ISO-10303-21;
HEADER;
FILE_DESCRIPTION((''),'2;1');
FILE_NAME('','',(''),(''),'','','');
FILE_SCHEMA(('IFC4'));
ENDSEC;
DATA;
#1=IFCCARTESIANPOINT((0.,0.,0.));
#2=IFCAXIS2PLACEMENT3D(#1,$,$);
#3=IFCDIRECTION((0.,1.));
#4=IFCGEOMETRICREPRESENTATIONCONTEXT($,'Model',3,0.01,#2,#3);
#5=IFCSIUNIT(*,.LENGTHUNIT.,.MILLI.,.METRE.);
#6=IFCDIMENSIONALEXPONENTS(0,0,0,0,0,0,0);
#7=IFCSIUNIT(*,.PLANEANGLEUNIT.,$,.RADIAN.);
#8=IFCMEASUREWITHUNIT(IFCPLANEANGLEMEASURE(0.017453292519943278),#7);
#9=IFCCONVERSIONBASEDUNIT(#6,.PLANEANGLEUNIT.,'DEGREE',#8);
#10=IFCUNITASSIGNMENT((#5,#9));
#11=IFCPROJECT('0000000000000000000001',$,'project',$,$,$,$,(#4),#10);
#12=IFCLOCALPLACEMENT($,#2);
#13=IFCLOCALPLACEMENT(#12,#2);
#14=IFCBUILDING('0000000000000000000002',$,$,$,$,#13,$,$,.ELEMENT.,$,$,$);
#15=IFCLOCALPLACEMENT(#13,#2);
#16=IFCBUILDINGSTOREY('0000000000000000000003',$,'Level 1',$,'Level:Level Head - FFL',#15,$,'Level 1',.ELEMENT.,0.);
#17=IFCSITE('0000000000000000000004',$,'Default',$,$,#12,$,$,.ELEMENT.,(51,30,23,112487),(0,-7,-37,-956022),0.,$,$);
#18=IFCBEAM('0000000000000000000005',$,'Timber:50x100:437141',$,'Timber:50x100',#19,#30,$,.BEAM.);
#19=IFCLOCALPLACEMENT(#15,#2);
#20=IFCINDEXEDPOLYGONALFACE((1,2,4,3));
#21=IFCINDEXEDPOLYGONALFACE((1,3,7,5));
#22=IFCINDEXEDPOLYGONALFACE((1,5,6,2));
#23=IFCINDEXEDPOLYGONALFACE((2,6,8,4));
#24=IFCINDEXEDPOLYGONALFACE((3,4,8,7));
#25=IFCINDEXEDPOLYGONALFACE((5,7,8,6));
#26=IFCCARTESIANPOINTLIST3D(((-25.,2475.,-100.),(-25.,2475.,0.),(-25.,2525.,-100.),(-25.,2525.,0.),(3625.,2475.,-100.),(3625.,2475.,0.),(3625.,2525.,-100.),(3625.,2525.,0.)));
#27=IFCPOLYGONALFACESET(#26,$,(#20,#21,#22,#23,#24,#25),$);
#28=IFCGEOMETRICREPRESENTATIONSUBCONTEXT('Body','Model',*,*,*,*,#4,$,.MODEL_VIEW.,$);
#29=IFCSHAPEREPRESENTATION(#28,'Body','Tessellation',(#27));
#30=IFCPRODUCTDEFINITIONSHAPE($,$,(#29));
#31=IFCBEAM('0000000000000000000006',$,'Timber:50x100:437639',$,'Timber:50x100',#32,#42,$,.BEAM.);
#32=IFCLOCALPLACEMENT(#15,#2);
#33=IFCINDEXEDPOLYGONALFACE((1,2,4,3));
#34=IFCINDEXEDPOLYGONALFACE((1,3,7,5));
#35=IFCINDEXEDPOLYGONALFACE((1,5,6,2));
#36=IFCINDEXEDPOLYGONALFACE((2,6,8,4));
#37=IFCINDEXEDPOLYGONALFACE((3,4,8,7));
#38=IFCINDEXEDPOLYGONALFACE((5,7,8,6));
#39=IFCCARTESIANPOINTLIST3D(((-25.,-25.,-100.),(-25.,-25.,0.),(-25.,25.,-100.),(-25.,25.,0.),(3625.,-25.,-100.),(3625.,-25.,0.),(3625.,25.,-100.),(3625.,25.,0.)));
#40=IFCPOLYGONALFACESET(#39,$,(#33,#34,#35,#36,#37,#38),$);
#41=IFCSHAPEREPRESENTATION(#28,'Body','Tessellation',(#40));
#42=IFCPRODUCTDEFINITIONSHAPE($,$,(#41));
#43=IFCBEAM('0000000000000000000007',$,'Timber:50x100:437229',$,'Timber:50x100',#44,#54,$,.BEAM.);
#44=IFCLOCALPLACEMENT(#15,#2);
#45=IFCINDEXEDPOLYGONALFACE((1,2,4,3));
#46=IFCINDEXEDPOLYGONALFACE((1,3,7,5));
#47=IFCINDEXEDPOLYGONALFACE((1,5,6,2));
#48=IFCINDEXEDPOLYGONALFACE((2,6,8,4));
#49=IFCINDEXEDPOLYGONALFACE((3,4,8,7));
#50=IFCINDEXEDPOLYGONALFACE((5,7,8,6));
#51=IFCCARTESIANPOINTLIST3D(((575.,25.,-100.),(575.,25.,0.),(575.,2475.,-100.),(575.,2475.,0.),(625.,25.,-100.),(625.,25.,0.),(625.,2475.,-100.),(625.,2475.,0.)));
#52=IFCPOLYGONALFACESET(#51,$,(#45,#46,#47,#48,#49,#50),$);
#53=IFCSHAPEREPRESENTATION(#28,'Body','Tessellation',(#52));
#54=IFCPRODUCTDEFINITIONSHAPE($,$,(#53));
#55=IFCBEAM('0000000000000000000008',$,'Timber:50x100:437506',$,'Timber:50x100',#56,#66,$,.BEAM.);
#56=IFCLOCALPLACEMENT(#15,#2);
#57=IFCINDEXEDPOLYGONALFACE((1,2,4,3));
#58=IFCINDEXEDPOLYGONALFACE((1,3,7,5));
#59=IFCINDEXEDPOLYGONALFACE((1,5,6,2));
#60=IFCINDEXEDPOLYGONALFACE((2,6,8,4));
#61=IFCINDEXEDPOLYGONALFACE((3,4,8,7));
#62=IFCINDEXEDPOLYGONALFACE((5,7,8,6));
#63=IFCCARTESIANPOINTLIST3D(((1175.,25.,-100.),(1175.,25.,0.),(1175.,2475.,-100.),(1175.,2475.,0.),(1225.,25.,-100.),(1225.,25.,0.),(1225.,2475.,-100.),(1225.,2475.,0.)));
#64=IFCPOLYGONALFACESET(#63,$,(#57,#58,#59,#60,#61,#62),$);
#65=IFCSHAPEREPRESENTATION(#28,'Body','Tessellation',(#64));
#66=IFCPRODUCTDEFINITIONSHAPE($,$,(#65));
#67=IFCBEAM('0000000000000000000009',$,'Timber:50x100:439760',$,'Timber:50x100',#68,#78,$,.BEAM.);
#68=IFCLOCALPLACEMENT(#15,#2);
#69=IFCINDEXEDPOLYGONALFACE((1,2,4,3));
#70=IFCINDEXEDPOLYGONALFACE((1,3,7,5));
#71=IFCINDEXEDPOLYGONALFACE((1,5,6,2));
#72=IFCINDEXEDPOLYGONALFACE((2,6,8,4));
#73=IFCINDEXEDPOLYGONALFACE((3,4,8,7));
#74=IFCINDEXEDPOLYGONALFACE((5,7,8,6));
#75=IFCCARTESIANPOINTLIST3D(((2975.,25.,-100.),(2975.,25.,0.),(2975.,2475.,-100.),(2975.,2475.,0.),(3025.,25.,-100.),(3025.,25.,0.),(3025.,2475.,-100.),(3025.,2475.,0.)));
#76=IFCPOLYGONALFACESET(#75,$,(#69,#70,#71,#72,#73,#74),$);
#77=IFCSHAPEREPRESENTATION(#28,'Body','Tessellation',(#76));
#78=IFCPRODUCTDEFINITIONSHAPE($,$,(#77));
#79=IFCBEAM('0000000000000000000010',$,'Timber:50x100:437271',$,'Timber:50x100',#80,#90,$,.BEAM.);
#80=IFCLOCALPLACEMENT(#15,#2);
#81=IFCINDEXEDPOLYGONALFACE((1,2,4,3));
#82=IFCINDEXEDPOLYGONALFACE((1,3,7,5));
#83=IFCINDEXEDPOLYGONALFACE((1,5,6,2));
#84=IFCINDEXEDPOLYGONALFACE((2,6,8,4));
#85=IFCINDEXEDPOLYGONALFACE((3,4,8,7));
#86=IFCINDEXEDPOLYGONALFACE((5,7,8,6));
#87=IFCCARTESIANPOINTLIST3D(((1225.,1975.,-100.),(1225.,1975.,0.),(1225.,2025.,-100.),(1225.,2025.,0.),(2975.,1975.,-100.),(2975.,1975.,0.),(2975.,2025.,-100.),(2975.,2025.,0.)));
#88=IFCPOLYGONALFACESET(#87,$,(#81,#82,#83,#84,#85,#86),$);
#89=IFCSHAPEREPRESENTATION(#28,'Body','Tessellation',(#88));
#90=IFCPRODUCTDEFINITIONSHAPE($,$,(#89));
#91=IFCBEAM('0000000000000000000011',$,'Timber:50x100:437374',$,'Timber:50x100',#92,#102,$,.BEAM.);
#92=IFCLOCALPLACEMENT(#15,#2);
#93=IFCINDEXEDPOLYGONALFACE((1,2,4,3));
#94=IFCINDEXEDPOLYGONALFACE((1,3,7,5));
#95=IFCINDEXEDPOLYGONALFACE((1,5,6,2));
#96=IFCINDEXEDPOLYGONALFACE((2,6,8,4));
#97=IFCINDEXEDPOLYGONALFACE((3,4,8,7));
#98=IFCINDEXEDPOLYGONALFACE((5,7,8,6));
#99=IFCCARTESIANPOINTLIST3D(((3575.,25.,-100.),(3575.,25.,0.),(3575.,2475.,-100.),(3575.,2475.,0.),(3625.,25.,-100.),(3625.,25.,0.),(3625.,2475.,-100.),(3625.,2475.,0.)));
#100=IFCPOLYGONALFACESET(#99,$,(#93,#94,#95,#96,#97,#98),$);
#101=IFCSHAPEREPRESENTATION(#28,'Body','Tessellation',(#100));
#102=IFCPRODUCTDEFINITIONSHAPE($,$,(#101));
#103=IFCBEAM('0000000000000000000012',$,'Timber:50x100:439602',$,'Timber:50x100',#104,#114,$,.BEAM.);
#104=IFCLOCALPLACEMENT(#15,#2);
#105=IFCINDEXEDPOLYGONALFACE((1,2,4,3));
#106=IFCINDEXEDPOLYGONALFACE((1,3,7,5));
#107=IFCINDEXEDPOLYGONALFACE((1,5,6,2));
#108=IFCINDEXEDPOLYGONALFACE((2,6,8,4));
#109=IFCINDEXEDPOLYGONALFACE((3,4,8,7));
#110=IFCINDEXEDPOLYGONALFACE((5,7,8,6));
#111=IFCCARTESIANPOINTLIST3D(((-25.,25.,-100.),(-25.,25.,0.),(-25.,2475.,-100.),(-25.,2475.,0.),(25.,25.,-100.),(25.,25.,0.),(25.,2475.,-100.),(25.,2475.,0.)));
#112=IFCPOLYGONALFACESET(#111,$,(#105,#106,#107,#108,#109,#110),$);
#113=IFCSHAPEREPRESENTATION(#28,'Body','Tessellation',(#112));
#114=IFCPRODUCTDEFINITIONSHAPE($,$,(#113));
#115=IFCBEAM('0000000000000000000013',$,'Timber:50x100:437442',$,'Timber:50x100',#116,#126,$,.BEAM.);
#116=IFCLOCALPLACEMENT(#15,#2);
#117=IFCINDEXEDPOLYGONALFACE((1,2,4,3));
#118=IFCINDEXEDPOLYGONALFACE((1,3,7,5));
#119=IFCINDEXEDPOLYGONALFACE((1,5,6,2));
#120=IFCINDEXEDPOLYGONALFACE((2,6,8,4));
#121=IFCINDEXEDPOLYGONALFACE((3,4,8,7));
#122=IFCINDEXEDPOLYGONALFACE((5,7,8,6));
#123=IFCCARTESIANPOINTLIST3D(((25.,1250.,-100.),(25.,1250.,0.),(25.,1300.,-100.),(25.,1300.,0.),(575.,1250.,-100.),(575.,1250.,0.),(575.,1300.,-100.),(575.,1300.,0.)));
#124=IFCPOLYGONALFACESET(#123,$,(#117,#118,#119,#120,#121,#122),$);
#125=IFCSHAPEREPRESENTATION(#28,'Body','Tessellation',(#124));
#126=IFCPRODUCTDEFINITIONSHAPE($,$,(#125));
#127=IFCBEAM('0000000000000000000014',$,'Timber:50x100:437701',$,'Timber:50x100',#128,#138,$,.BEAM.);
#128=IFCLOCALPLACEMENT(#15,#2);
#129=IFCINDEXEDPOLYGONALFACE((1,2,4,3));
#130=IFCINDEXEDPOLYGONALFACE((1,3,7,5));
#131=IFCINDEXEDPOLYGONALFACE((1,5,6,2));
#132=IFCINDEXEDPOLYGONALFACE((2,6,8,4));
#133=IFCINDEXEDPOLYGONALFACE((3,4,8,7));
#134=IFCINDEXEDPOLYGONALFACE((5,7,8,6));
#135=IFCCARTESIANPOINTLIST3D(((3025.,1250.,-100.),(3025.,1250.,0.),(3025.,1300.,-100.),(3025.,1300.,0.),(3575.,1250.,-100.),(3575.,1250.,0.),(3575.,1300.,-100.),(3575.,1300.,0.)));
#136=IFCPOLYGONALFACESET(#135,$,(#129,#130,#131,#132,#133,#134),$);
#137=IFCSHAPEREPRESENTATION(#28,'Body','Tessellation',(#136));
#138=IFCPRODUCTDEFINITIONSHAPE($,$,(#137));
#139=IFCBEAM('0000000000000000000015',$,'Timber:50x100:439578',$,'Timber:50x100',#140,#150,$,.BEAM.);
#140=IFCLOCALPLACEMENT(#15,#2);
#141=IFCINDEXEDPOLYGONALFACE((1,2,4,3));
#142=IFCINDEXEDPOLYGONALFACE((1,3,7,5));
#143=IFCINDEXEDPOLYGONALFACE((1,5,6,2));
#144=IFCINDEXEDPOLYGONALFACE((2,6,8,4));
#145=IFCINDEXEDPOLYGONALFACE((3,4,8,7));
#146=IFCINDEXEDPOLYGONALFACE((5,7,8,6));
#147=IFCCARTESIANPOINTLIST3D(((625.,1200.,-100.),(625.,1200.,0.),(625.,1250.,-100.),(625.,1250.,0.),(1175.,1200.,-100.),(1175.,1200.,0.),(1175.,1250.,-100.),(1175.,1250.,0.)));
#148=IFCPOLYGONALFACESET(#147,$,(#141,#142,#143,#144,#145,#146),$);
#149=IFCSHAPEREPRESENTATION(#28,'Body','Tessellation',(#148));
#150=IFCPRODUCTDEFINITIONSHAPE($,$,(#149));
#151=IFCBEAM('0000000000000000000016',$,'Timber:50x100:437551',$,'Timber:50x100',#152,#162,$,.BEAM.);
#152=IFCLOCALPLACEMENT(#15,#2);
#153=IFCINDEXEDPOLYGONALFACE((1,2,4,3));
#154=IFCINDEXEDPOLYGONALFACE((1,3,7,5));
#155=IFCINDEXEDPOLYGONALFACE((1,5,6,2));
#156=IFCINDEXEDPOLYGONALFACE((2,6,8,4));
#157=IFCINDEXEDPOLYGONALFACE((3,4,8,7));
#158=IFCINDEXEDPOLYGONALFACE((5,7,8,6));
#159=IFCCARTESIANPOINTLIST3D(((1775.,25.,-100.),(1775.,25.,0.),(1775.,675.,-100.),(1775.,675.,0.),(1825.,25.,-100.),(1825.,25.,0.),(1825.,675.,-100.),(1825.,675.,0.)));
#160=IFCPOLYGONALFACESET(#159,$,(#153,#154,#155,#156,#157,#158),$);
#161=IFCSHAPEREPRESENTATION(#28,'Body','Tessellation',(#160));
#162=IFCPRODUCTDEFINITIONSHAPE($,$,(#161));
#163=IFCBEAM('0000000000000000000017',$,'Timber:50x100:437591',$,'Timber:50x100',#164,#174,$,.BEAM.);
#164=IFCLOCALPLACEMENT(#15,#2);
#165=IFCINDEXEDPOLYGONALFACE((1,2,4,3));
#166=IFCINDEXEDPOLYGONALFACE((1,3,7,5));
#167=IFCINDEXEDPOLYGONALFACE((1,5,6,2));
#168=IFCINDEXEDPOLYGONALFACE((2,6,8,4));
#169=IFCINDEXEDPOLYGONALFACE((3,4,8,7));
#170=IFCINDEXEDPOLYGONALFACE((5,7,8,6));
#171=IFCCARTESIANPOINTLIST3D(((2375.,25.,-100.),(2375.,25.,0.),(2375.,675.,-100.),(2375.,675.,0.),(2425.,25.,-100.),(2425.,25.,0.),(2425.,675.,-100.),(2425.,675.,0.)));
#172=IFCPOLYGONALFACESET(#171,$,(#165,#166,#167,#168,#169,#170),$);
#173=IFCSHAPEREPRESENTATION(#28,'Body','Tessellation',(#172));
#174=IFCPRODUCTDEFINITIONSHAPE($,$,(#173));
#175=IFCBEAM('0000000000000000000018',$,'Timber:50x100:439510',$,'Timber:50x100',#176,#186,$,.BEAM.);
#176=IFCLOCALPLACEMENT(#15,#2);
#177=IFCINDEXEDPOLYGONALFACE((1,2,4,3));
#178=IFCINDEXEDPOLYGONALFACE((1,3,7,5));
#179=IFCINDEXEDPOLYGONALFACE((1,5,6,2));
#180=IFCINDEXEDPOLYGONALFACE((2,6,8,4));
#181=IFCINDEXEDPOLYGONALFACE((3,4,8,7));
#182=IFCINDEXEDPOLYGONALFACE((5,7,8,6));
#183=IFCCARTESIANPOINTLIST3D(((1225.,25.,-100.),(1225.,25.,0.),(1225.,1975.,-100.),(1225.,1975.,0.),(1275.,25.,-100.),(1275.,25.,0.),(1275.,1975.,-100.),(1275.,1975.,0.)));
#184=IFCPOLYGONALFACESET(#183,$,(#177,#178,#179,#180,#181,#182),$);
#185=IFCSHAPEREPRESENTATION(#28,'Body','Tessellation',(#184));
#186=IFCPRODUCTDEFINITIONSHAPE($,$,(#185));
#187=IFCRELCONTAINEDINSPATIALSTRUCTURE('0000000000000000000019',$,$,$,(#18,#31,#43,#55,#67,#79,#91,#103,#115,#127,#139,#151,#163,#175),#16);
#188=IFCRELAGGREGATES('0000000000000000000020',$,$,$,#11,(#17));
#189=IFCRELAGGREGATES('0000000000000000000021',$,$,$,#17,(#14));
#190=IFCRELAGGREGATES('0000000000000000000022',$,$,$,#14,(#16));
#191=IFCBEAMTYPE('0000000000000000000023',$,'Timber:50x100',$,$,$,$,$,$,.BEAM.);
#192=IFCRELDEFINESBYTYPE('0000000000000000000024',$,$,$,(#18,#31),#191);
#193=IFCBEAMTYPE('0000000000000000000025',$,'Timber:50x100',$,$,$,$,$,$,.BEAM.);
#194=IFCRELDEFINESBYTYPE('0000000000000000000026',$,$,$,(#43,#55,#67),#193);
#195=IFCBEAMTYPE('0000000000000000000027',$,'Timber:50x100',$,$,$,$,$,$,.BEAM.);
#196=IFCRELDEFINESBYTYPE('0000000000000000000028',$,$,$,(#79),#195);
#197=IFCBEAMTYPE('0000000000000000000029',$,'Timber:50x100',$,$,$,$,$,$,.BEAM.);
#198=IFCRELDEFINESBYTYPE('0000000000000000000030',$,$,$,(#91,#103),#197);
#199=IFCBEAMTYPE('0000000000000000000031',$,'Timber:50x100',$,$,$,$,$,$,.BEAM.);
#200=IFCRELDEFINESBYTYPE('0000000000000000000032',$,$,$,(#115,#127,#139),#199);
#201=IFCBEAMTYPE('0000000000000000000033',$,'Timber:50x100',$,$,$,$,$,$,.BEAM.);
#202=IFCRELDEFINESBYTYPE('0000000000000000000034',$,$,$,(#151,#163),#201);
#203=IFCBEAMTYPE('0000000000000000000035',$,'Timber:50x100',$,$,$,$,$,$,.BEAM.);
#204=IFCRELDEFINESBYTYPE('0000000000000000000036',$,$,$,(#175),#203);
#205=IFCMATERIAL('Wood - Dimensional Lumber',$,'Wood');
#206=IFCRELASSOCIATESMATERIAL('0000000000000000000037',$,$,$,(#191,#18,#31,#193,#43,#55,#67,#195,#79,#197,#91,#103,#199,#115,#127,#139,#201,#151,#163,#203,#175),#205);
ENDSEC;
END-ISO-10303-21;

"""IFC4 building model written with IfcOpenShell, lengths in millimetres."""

from ifc_helpers import new_model, entity, si_unit, converted_unit, direction, frame, origin, place, context, subcontext, project, spatial, indexed_curve, outline, extrude, source, transform, mapped, material, type_object, type_shapes, element, save


model = new_model("IFC4")

# Units and contexts
model_context = context("Model", 3, precision=0.01, world=origin(), true_north=direction((0.0, 1.0)))
body_context = subcontext(model_context, "Body", "Model", "MODEL_VIEW")
ifc_project = project(units=[si_unit("LENGTHUNIT", "METRE", prefix="MILLI"), converted_unit("PLANEANGLEUNIT", "DEGREE", entity("IfcPlaneAngleMeasure", 0.017453292519943278), si_unit("PLANEANGLEUNIT", "RADIAN"), dimensions=[0, 0, 0, 0, 0, 0, 0])], contexts=[model_context])

# Site, building, storey
site_placement = place(None, origin())
site = spatial("IfcSite", under=ifc_project, at=site_placement, Name="Default", CompositionType="ELEMENT", RefLatitude=(51, 30, 23, 112487), RefLongitude=(0, -7, -37, -956022), RefElevation=0.0)
building_placement = place(site_placement, origin())
building = spatial("IfcBuilding", under=site, at=building_placement, CompositionType="ELEMENT")
storey_placement = place(building_placement, origin())
storey = spatial("IfcBuildingStorey", under=building, at=storey_placement, Name="Level 1", ObjectType="Level:Level Head - FFL", LongName="Level 1", CompositionType="ELEMENT", Elevation=0.0)

# Beams
ifc_material = material(Name="Wood - Dimensional Lumber", Category="Wood")
beam_type_1 = type_object("IfcBeamType", Name="Timber:50x100", PredefinedType="BEAM", material=ifc_material)
shared_shape_1 = source(origin(), body_context, "Body", "SweptSolid", [
    extrude(outline(indexed_curve([(-1825.0, -25.0), (1825.0, -25.0), (1825.0, 25.0), (-1825.0, 25.0), (-1825.0, -25.0)], self_intersect=False)), frame((0.0, 0.0, -50.0), z_axis=(0.0, 0.0, 1.0), x_axis=(-1.0, 0.0, 0.0)), (0.0, 0.0, 1.0), 100.0),
])
type_shapes(beam_type_1, [shared_shape_1])
for number, where, name in (
    (1, (1800.0, 2500.0, -50.0), "Timber:50x100:437141"),
    (2, (1800.0, 0.0, -50.0), "Timber:50x100:437639"),
):
    element("IfcBeam", number, at=place(storey_placement, frame(where)), inside=storey, type_object=beam_type_1, material=ifc_material, Name=name, ObjectType="Timber:50x100", PredefinedType="BEAM", context=body_context, shape_type="MappedRepresentation", body=[
        mapped(shared_shape_1, transform((0.0, 0.0, 0.0), scale=1.0)),
    ])
beam_type_2 = type_object("IfcBeamType", Name="Timber:50x100", PredefinedType="BEAM", material=ifc_material)
shared_shape_2 = source(origin(), body_context, "Body", "SweptSolid", [
    extrude(outline(indexed_curve([(-1225.0, -25.0), (1225.0, -25.0), (1225.0, 25.0), (-1225.0, 25.0), (-1225.0, -25.0)], self_intersect=False)), frame((0.0, 0.0, -50.0), z_axis=(0.0, 0.0, 1.0), x_axis=(-1.0, 0.0, 0.0)), (0.0, 0.0, 1.0), 100.0),
])
type_shapes(beam_type_2, [shared_shape_2])
for number, where, z_axis, x_axis, name in (
    (3, (600.0, 1250.0, -50.0), (0.0, 0.0, 1.0), (0.0, -1.0, 0.0), "Timber:50x100:437229"),
    (4, (1200.0, 1250.0, -50.0), (0.0, 0.0, 1.0), (0.0, -1.0, 0.0), "Timber:50x100:437506"),
    (5, (3000.0, 1250.0, -50.0), (0.0, 0.0, 1.0), (0.0, -1.0, 0.0), "Timber:50x100:439760"),
):
    element("IfcBeam", number, at=place(storey_placement, frame(where, z_axis=z_axis, x_axis=x_axis)), inside=storey, type_object=beam_type_2, material=ifc_material, Name=name, ObjectType="Timber:50x100", PredefinedType="BEAM", context=body_context, shape_type="MappedRepresentation", body=[
        mapped(shared_shape_2, transform((0.0, 0.0, 0.0), scale=1.0)),
    ])
beam_type_3 = type_object("IfcBeamType", Name="Timber:50x100", PredefinedType="BEAM", material=ifc_material)
shared_shape_3 = source(origin(), body_context, "Body", "SweptSolid", [
    extrude(outline(indexed_curve([(-875.0, -25.0), (875.0, -25.0), (875.0, 25.0), (-875.0, 25.0), (-875.0, -25.0)], self_intersect=False)), frame((0.0, 0.0, -50.0), z_axis=(0.0, 0.0, 1.0), x_axis=(-1.0, 0.0, 0.0)), (0.0, 0.0, 1.0), 100.0),
])
type_shapes(beam_type_3, [shared_shape_3])
beam_1_placement = place(storey_placement, frame((2100.0, 2000.0, -50.0)))
element("IfcBeam", 6, at=beam_1_placement, inside=storey, type_object=beam_type_3, material=ifc_material, Name="Timber:50x100:437271", ObjectType="Timber:50x100", PredefinedType="BEAM", context=body_context, shape_type="MappedRepresentation", body=[
    mapped(shared_shape_3, transform((0.0, 0.0, 0.0), scale=1.0)),
])
beam_type_4 = type_object("IfcBeamType", Name="Timber:50x100", PredefinedType="BEAM", material=ifc_material)
shared_shape_4 = source(origin(), body_context, "Body", "SweptSolid", [
    extrude(outline(indexed_curve([(-1225.0, -25.0), (1225.0, -25.0), (1225.0, 25.0), (-1225.0, 25.0), (-1225.0, -25.0)], self_intersect=False)), frame((0.0, 0.0, -50.0), z_axis=(0.0, 0.0, 1.0), x_axis=(-1.0, 0.0, 0.0)), (0.0, 0.0, 1.0), 100.0),
])
type_shapes(beam_type_4, [shared_shape_4])
for number, where, z_axis, x_axis, name in (
    (7, (3600.0, 1250.0, -50.0), (0.0, 0.0, 1.0), (0.0, -1.0, 0.0), "Timber:50x100:437374"),
    (8, (0.0, 1250.0, -50.0), (0.0, 0.0, 1.0), (0.0, -1.0, 0.0), "Timber:50x100:439602"),
):
    element("IfcBeam", number, at=place(storey_placement, frame(where, z_axis=z_axis, x_axis=x_axis)), inside=storey, type_object=beam_type_4, material=ifc_material, Name=name, ObjectType="Timber:50x100", PredefinedType="BEAM", context=body_context, shape_type="MappedRepresentation", body=[
        mapped(shared_shape_4, transform((0.0, 0.0, 0.0), scale=1.0)),
    ])
beam_type_5 = type_object("IfcBeamType", Name="Timber:50x100", PredefinedType="BEAM", material=ifc_material)
shared_shape_5 = source(origin(), body_context, "Body", "SweptSolid", [
    extrude(outline(indexed_curve([(-275.0, -25.0), (275.0, -25.0), (275.0, 25.0), (-275.0, 25.0), (-275.0, -25.0)], self_intersect=False)), frame((0.0, 0.0, -50.0), z_axis=(0.0, 0.0, 1.0), x_axis=(-1.0, 0.0, 0.0)), (0.0, 0.0, 1.0), 100.0),
])
type_shapes(beam_type_5, [shared_shape_5])
for number, where, name in (
    (9, (300.0, 1275.0, -50.0), "Timber:50x100:437442"),
    (10, (3300.0, 1275.0, -50.0), "Timber:50x100:437701"),
    (11, (900.0, 1225.0, -50.0), "Timber:50x100:439578"),
):
    element("IfcBeam", number, at=place(storey_placement, frame(where)), inside=storey, type_object=beam_type_5, material=ifc_material, Name=name, ObjectType="Timber:50x100", PredefinedType="BEAM", context=body_context, shape_type="MappedRepresentation", body=[
        mapped(shared_shape_5, transform((0.0, 0.0, 0.0), scale=1.0)),
    ])
beam_type_6 = type_object("IfcBeamType", Name="Timber:50x100", PredefinedType="BEAM", material=ifc_material)
shared_shape_6 = source(origin(), body_context, "Body", "SweptSolid", [
    extrude(outline(indexed_curve([(-325.0, -25.0), (325.0, -25.0), (325.0, 25.0), (-325.0, 25.0), (-325.0, -25.0)], self_intersect=False)), frame((0.0, 0.0, -50.0), z_axis=(0.0, 0.0, 1.0), x_axis=(-1.0, 0.0, 0.0)), (0.0, 0.0, 1.0), 100.0),
])
type_shapes(beam_type_6, [shared_shape_6])
for number, where, z_axis, x_axis, name in (
    (12, (1800.0, 350.0, -50.0), (0.0, 0.0, 1.0), (0.0, -1.0, 0.0), "Timber:50x100:437551"),
    (13, (2400.0, 350.0, -50.0), (0.0, 0.0, 1.0), (0.0, -1.0, 0.0), "Timber:50x100:437591"),
):
    element("IfcBeam", number, at=place(storey_placement, frame(where, z_axis=z_axis, x_axis=x_axis)), inside=storey, type_object=beam_type_6, material=ifc_material, Name=name, ObjectType="Timber:50x100", PredefinedType="BEAM", context=body_context, shape_type="MappedRepresentation", body=[
        mapped(shared_shape_6, transform((0.0, 0.0, 0.0), scale=1.0)),
    ])
beam_type_7 = type_object("IfcBeamType", Name="Timber:50x100", PredefinedType="BEAM", material=ifc_material)
shared_shape_7 = source(origin(), body_context, "Body", "SweptSolid", [
    extrude(outline(indexed_curve([(-975.0, -25.0), (975.0, -25.0), (975.0, 25.0), (-975.0, 25.0), (-975.0, -25.0)], self_intersect=False)), frame((0.0, 0.0, -50.0), z_axis=(0.0, 0.0, 1.0), x_axis=(-1.0, 0.0, 0.0)), (0.0, 0.0, 1.0), 100.0),
])
type_shapes(beam_type_7, [shared_shape_7])
for number, where, z_axis, x_axis, name in (
    (14, (1250.0, 1000.0, -50.0), (0.0, 0.0, 1.0), (0.0, 1.0, 0.0), "Timber:50x100:439510"),
):
    element("IfcBeam", number, at=place(storey_placement, frame(where, z_axis=z_axis, x_axis=x_axis)), inside=storey, type_object=beam_type_7, material=ifc_material, Name=name, ObjectType="Timber:50x100", PredefinedType="BEAM", context=body_context, shape_type="MappedRepresentation", body=[
        mapped(shared_shape_7, transform((0.0, 0.0, 0.0), scale=1.0)),
    ])

save(model, "model.ifc")
